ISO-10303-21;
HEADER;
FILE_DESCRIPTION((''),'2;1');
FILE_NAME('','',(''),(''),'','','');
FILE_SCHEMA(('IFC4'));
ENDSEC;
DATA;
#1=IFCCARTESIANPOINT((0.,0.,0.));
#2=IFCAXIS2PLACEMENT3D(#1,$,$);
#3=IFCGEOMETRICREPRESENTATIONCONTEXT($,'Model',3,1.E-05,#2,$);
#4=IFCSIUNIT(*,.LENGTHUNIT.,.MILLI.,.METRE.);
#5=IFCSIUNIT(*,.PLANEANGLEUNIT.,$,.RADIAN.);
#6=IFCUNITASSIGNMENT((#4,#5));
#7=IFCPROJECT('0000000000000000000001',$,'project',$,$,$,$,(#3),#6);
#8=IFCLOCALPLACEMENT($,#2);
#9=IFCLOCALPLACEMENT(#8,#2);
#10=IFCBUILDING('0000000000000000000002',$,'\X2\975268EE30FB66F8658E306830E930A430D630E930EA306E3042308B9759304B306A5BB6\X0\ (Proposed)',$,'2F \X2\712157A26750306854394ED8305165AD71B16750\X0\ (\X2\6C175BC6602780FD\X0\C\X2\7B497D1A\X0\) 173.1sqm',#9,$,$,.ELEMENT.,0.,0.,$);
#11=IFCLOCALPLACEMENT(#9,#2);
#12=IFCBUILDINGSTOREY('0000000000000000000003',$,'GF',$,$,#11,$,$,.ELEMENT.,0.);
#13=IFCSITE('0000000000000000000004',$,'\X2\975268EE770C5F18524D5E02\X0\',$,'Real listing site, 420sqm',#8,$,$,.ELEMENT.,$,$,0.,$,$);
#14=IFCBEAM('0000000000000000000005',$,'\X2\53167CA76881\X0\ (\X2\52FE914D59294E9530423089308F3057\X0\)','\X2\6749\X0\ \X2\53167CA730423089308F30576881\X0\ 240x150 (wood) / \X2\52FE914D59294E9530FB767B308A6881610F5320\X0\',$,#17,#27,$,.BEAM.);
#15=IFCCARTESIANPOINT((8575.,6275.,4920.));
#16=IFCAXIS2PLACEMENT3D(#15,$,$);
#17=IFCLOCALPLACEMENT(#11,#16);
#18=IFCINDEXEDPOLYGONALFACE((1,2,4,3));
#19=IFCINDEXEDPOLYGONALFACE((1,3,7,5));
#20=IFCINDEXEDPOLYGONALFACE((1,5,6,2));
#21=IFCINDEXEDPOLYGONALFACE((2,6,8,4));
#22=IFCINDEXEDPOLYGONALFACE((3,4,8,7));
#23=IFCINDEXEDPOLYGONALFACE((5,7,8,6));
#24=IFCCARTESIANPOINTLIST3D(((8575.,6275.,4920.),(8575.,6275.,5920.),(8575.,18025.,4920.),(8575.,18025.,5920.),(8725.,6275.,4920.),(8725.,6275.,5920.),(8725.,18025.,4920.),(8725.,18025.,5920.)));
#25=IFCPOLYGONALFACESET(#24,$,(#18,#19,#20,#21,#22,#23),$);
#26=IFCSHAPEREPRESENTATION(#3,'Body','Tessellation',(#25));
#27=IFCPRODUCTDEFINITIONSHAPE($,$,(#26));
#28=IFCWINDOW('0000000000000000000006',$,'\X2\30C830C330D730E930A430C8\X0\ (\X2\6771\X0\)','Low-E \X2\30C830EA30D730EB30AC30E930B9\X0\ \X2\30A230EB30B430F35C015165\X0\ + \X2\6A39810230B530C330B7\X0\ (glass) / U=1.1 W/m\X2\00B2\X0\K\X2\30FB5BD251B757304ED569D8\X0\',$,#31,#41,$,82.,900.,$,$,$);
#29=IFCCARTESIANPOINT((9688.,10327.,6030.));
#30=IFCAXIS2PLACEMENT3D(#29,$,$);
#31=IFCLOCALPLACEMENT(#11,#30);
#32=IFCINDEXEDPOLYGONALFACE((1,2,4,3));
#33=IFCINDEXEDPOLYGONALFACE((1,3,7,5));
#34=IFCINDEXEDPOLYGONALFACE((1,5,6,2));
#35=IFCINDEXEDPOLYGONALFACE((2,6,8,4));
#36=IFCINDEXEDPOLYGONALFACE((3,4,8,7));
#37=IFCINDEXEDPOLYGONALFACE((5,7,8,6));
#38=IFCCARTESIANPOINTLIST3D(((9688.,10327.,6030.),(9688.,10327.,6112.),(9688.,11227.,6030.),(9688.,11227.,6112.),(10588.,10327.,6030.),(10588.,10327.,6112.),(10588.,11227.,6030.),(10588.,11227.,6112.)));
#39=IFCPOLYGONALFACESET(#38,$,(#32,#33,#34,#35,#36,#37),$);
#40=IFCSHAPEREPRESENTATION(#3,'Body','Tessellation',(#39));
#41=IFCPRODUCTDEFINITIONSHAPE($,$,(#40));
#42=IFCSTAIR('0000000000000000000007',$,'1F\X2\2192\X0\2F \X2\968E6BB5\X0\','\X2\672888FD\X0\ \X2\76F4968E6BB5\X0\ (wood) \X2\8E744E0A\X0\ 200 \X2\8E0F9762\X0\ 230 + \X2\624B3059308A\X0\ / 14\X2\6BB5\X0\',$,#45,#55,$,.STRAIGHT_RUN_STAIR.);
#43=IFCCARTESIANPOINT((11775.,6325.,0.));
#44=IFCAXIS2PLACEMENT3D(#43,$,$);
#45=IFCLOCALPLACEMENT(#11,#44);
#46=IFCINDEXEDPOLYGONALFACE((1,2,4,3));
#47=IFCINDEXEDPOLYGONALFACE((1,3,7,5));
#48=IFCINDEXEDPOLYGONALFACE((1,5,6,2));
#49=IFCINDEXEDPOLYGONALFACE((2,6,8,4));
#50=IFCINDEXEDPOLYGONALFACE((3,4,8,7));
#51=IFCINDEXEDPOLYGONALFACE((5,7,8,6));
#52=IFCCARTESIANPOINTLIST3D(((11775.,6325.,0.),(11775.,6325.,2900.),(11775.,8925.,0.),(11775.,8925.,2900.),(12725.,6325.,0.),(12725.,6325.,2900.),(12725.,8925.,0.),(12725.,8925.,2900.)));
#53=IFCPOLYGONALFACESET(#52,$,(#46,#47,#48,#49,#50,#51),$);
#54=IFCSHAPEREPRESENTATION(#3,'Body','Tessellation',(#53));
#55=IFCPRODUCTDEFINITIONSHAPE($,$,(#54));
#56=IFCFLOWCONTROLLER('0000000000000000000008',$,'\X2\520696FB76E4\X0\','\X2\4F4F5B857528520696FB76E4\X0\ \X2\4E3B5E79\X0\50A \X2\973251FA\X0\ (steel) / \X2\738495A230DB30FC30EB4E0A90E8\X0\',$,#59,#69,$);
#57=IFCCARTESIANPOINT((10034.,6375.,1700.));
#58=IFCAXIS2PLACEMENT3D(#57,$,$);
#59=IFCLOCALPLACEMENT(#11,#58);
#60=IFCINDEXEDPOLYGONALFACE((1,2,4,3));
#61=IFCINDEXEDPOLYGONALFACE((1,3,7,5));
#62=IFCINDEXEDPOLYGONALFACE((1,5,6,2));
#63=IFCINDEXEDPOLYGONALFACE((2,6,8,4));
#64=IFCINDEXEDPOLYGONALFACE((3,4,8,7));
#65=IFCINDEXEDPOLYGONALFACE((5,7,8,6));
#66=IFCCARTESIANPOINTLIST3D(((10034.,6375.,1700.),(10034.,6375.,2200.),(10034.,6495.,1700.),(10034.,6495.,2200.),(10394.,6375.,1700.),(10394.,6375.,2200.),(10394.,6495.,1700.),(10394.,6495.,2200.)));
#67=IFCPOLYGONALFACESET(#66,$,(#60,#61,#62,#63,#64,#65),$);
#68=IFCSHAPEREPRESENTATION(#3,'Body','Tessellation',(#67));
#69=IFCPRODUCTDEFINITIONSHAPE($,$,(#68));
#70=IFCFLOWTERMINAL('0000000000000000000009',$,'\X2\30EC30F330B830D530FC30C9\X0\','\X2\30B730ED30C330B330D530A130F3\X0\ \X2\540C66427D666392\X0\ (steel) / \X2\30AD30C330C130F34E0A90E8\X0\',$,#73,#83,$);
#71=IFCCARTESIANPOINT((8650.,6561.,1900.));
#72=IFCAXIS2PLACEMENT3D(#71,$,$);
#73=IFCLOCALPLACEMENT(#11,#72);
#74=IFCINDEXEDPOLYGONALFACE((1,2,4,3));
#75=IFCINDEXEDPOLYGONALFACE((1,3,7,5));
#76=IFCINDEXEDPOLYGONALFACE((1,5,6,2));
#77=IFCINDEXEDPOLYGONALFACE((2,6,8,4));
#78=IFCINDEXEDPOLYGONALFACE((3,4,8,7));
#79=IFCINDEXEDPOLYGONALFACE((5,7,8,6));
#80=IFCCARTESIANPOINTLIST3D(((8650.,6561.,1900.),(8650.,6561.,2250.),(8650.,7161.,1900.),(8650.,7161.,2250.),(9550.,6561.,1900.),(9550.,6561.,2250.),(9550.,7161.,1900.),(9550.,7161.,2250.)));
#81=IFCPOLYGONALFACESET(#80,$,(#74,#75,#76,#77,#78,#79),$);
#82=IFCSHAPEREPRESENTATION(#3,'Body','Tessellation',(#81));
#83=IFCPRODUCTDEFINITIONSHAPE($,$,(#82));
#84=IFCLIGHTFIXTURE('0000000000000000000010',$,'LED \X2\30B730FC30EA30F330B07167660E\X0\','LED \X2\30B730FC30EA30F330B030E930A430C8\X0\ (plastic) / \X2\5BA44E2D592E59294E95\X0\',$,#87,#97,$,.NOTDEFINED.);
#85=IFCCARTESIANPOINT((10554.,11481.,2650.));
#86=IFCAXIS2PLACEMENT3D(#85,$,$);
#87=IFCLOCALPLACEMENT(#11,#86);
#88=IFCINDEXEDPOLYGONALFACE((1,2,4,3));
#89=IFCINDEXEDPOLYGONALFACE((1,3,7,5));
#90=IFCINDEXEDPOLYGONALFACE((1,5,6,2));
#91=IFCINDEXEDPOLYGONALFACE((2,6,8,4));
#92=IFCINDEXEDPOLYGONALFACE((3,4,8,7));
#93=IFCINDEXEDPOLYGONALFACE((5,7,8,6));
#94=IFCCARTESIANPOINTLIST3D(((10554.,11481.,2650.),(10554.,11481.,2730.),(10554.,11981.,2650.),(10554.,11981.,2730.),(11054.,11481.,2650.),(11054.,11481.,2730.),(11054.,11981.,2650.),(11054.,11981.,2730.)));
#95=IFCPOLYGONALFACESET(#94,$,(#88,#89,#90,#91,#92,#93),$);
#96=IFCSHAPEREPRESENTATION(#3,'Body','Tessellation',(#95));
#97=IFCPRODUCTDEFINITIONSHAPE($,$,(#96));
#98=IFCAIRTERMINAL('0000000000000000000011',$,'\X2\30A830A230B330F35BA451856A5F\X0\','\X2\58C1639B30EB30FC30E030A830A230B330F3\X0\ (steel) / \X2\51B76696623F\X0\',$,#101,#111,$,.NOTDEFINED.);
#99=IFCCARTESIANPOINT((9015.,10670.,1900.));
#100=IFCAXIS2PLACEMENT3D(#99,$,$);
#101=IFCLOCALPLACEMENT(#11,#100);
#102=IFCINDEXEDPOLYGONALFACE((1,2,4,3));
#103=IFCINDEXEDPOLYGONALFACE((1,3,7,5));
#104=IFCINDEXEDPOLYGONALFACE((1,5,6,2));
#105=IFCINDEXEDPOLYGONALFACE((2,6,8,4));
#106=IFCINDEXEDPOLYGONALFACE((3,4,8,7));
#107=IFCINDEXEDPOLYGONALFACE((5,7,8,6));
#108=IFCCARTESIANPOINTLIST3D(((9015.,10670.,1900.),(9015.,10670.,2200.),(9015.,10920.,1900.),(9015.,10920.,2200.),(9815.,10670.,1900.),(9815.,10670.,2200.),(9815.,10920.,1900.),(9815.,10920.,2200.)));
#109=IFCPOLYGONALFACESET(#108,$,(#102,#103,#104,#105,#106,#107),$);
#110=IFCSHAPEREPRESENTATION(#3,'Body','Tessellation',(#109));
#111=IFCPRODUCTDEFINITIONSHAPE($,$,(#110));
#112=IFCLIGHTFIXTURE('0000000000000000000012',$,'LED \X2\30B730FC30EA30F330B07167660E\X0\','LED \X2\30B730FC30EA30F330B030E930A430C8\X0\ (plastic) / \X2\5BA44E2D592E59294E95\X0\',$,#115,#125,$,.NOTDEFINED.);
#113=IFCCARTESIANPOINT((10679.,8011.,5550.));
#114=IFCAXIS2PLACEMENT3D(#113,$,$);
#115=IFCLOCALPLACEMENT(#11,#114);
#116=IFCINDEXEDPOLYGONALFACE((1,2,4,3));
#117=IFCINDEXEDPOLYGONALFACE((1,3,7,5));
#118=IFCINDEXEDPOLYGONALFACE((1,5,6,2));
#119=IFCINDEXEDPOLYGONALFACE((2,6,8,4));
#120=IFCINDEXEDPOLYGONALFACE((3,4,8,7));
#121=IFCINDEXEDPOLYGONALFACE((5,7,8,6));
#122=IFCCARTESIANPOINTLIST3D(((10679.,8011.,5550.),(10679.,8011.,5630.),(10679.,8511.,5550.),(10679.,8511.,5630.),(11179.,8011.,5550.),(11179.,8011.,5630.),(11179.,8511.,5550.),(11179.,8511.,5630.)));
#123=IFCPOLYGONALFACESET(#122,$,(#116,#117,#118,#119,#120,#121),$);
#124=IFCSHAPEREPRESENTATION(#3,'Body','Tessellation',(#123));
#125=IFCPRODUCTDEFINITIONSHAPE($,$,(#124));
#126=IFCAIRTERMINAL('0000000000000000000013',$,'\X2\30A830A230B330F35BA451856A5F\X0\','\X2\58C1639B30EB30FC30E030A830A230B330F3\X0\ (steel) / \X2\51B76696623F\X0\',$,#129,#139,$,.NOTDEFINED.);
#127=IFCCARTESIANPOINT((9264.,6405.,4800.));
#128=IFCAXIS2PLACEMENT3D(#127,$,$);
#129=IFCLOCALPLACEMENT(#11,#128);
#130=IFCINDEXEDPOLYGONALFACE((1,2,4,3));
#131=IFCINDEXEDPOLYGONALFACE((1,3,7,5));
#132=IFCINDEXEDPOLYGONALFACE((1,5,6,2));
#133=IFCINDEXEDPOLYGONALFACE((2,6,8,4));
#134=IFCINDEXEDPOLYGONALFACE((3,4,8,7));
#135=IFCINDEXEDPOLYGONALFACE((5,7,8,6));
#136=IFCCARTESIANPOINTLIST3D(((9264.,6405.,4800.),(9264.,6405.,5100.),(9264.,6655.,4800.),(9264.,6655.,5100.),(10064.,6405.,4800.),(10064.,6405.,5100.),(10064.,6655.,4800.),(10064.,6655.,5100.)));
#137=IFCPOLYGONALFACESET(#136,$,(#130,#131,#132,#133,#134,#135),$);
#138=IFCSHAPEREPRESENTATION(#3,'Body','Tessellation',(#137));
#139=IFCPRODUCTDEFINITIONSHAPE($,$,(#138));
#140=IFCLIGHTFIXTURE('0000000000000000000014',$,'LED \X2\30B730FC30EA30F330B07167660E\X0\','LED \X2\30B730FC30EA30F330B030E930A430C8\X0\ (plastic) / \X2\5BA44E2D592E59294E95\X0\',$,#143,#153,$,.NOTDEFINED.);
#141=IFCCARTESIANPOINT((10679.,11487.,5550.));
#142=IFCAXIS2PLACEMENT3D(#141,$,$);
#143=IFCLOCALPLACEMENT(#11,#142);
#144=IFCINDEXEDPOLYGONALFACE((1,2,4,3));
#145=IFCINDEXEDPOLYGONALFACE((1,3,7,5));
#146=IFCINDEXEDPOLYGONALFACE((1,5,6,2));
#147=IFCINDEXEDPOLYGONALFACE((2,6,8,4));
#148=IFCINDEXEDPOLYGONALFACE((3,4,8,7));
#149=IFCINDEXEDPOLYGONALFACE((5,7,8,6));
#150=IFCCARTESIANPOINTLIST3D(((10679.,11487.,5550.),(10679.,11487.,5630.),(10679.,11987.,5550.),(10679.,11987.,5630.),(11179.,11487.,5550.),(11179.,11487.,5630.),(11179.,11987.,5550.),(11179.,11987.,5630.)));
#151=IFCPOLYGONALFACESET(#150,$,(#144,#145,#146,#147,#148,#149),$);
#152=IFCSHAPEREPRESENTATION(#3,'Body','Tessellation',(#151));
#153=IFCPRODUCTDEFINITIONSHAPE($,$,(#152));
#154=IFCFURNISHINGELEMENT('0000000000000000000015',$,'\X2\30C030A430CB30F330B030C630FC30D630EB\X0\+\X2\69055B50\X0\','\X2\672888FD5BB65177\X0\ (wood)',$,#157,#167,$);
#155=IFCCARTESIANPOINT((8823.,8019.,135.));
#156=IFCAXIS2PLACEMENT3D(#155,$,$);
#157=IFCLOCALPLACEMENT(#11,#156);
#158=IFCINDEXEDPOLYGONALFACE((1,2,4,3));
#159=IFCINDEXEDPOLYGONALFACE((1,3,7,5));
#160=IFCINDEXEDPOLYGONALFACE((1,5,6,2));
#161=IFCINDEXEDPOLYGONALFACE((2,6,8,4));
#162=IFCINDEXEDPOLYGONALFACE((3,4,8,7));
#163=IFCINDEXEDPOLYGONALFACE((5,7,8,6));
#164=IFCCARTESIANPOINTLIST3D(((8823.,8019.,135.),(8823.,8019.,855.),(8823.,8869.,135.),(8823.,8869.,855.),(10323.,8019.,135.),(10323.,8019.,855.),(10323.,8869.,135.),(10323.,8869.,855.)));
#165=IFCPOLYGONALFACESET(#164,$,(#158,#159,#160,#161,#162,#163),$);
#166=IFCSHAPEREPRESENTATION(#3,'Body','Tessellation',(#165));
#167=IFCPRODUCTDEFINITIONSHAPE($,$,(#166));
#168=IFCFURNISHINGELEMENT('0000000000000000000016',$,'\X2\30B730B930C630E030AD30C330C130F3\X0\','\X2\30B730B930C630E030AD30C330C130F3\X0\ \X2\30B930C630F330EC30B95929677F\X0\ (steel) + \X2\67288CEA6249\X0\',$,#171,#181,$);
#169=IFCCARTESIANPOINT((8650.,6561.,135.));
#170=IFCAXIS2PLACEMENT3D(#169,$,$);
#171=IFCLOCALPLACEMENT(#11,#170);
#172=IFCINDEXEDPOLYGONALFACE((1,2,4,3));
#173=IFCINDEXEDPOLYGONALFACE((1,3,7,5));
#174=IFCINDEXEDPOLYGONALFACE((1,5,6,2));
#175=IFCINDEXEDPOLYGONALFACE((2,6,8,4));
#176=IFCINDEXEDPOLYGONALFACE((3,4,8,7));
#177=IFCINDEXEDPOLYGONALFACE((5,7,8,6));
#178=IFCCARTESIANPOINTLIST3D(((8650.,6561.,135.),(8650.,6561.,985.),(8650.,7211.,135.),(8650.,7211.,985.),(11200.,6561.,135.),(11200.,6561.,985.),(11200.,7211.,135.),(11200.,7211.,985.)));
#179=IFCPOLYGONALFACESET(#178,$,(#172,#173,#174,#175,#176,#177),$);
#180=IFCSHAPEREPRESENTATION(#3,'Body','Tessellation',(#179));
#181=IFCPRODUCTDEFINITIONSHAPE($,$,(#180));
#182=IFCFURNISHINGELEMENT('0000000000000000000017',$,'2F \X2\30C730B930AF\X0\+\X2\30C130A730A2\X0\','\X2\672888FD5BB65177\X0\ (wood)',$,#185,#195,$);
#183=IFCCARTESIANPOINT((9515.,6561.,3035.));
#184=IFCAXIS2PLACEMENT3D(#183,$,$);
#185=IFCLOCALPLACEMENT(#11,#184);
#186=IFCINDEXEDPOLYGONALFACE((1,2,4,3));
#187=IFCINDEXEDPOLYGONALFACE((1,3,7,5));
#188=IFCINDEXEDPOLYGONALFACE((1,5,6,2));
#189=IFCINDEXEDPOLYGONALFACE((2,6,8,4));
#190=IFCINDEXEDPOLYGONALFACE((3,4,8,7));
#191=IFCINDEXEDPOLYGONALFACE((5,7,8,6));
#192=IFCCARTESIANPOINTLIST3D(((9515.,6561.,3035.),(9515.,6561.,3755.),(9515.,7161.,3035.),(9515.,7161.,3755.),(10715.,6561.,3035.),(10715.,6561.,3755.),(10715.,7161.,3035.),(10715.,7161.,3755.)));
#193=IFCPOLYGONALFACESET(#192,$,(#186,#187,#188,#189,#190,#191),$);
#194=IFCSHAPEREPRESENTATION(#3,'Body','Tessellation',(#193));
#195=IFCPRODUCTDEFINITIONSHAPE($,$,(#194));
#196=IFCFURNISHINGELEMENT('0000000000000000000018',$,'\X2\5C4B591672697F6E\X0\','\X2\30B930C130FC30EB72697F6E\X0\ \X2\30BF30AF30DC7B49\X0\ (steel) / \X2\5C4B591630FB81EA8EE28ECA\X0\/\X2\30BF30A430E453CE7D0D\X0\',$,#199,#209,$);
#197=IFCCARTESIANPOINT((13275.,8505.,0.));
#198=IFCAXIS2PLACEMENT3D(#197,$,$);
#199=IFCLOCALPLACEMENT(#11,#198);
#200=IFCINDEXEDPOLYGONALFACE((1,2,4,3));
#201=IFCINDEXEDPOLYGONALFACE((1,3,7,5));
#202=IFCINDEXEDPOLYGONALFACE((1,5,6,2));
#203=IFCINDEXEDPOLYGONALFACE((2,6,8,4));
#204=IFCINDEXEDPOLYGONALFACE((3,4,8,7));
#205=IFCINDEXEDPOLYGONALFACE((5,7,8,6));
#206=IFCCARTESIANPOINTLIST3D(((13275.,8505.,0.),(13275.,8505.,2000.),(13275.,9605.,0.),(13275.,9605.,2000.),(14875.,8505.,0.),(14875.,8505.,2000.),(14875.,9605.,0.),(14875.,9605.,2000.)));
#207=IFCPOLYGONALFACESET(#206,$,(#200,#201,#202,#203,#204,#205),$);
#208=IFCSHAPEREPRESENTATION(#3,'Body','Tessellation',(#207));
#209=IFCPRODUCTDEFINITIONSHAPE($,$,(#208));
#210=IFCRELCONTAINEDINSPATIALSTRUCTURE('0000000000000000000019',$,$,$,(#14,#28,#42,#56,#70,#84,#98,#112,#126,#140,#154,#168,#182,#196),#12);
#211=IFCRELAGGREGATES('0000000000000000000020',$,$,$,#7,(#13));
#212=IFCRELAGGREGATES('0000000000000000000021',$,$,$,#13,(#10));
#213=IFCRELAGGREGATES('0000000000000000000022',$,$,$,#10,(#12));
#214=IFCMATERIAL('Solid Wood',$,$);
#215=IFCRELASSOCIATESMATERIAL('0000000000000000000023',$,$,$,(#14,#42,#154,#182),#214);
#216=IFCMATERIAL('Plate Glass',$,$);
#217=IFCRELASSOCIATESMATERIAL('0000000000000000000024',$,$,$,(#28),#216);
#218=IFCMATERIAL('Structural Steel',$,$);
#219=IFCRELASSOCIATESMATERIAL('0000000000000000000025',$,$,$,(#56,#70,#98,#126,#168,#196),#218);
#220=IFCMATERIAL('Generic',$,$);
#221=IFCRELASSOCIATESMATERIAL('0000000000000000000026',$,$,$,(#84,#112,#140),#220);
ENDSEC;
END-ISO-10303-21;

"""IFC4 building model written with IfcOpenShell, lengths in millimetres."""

from ifc_helpers import new_model, si_unit, frame, frame_2d, origin, place, context, project, spatial, rectangle, extrude, material, element, save


model = new_model("IFC4")

# Units and contexts
model_context = context("Model", 3, precision=1e-05, world=origin())
ifc_project = project(units=[si_unit("LENGTHUNIT", "METRE", prefix="MILLI"), si_unit("PLANEANGLEUNIT", "RADIAN")], contexts=[model_context])

# Site, building, storey
site_placement = place(None, origin())
site = spatial("IfcSite", under=ifc_project, at=site_placement, Name="青森県弘前市", ObjectType="Real listing site, 420sqm", CompositionType="ELEMENT", RefElevation=0.0)
building_placement = place(site_placement, origin())
building = spatial("IfcBuilding", under=site, at=building_placement, Name="青森・書斎とライブラリのある静かな家 (Proposed)", ObjectType="2F 無垢材と吹付け断熱材 (気密性能C等級) 173.1sqm", CompositionType="ELEMENT", ElevationOfRefHeight=0.0, ElevationOfTerrain=0.0)
storey_placement = place(building_placement, origin())
storey = spatial("IfcBuildingStorey", under=building, at=storey_placement, Name="GF", CompositionType="ELEMENT", Elevation=0.0)

# Shared definitions
ifc_material_1 = material(Name="Solid Wood")

# Beam
beam_placement = place(storey_placement, frame((8575.0, 6275.0, 4920.0)))
element("IfcBeam", 1, at=beam_placement, inside=storey, material=ifc_material_1, Name="化粧梁 (勾配天井あらわし)", Description="杉 化粧あらわし梁 240x150 (wood) / 勾配天井・登り梁意匠", PredefinedType="BEAM", context=model_context, shape_type="SweptSolid", body=[
    extrude(rectangle(XDim=150.0, YDim=11750.0, at=frame_2d((75.0, 5875.0))), frame((8575.0, 6275.0, 4920.0)), (0.0, 0.0, 1.0), 1000.0),
])

# Window
ifc_material_2 = material(Name="Plate Glass")
window_placement = place(storey_placement, frame((9688.0, 10327.0, 6030.0)))
element("IfcWindow", 2, at=window_placement, inside=storey, material=ifc_material_2, Name="トップライト (東)", Description="Low-E トリプルガラス アルゴン封入 + 樹脂サッシ (glass) / U=1.1 W/m²K・寒冷地仕様", OverallHeight=82.0, OverallWidth=900.0, context=model_context, shape_type="SweptSolid", body=[
    extrude(rectangle(XDim=900.0, YDim=900.0, at=frame_2d((450.0, 450.0))), frame((9688.0, 10327.0, 6030.0)), (0.0, 0.0, 1.0), 82.0),
])

# Stair
stair_placement = place(storey_placement, frame((11775.0, 6325.0, 0.0)))
element("IfcStair", 3, at=stair_placement, inside=storey, material=ifc_material_1, Name="1F→2F 階段", Description="木製 直階段 (wood) 蹴上 200 踏面 230 + 手すり / 14段", PredefinedType="STRAIGHT_RUN_STAIR", context=model_context, shape_type="SweptSolid", body=[
    extrude(rectangle(XDim=950.0, YDim=2600.0, at=frame_2d((475.0, 1300.0))), frame((11775.0, 6325.0, 0.0)), (0.0, 0.0, 1.0), 2900.0),
])

# Flow controller
ifc_material_3 = material(Name="Structural Steel")
flow_controller_placement = place(storey_placement, frame((10034.0, 6375.0, 1700.0)))
element("IfcFlowController", 4, at=flow_controller_placement, inside=storey, material=ifc_material_3, Name="分電盤", Description="住宅用分電盤 主幹50A 露出 (steel) / 玄関ホール上部", context=model_context, shape_type="SweptSolid", body=[
    extrude(rectangle(XDim=360.0, YDim=120.0, at=frame_2d((180.0, 60.0))), frame((10034.0, 6375.0, 1700.0)), (0.0, 0.0, 1.0), 500.0),
])

# Flow terminal
flow_terminal_placement = place(storey_placement, frame((8650.0, 6561.0, 1900.0)))
element("IfcFlowTerminal", 5, at=flow_terminal_placement, inside=storey, material=ifc_material_3, Name="レンジフード", Description="シロッコファン 同時給排 (steel) / キッチン上部", context=model_context, shape_type="SweptSolid", body=[
    extrude(rectangle(XDim=900.0, YDim=600.0, at=frame_2d((450.0, 300.0))), frame((8650.0, 6561.0, 1900.0)), (0.0, 0.0, 1.0), 350.0),
])

# Light fixture
ifc_material_4 = material(Name="Generic")
light_fixture_1_placement = place(storey_placement, frame((10554.0, 11481.0, 2650.0)))
element("IfcLightFixture", 6, at=light_fixture_1_placement, inside=storey, material=ifc_material_4, Name="LED シーリング照明", Description="LED シーリングライト (plastic) / 室中央天井", PredefinedType="NOTDEFINED", context=model_context, shape_type="SweptSolid", body=[
    extrude(rectangle(XDim=500.0, YDim=500.0, at=frame_2d((250.0, 250.0))), frame((10554.0, 11481.0, 2650.0)), (0.0, 0.0, 1.0), 80.0),
])

# Air terminal
air_terminal_1_placement = place(storey_placement, frame((9015.0, 10670.0, 1900.0)))
element("IfcAirTerminal", 7, at=air_terminal_1_placement, inside=storey, material=ifc_material_3, Name="エアコン室内機", Description="壁掛ルームエアコン (steel) / 冷暖房", PredefinedType="NOTDEFINED", context=model_context, shape_type="SweptSolid", body=[
    extrude(rectangle(XDim=800.0, YDim=250.0, at=frame_2d((400.0, 125.0))), frame((9015.0, 10670.0, 1900.0)), (0.0, 0.0, 1.0), 300.0),
])

# Light fixture
light_fixture_2_placement = place(storey_placement, frame((10679.0, 8011.0, 5550.0)))
element("IfcLightFixture", 8, at=light_fixture_2_placement, inside=storey, material=ifc_material_4, Name="LED シーリング照明", Description="LED シーリングライト (plastic) / 室中央天井", PredefinedType="NOTDEFINED", context=model_context, shape_type="SweptSolid", body=[
    extrude(rectangle(XDim=500.0, YDim=500.0, at=frame_2d((250.0, 250.0))), frame((10679.0, 8011.0, 5550.0)), (0.0, 0.0, 1.0), 80.0),
])

# Air terminal
air_terminal_2_placement = place(storey_placement, frame((9264.0, 6405.0, 4800.0)))
element("IfcAirTerminal", 9, at=air_terminal_2_placement, inside=storey, material=ifc_material_3, Name="エアコン室内機", Description="壁掛ルームエアコン (steel) / 冷暖房", PredefinedType="NOTDEFINED", context=model_context, shape_type="SweptSolid", body=[
    extrude(rectangle(XDim=800.0, YDim=250.0, at=frame_2d((400.0, 125.0))), frame((9264.0, 6405.0, 4800.0)), (0.0, 0.0, 1.0), 300.0),
])

# Light fixture
light_fixture_3_placement = place(storey_placement, frame((10679.0, 11487.0, 5550.0)))
element("IfcLightFixture", 10, at=light_fixture_3_placement, inside=storey, material=ifc_material_4, Name="LED シーリング照明", Description="LED シーリングライト (plastic) / 室中央天井", PredefinedType="NOTDEFINED", context=model_context, shape_type="SweptSolid", body=[
    extrude(rectangle(XDim=500.0, YDim=500.0, at=frame_2d((250.0, 250.0))), frame((10679.0, 11487.0, 5550.0)), (0.0, 0.0, 1.0), 80.0),
])

# Furnishing elements
furnishing_1_placement = place(storey_placement, frame((8823.0, 8019.0, 135.0)))
element("IfcFurnishingElement", 11, at=furnishing_1_placement, inside=storey, material=ifc_material_1, Name="ダイニングテーブル+椅子", Description="木製家具 (wood)", context=model_context, shape_type="SweptSolid", body=[
    extrude(rectangle(XDim=1500.0, YDim=850.0, at=frame_2d((750.0, 425.0))), frame((8823.0, 8019.0, 135.0)), (0.0, 0.0, 1.0), 720.0),
])
furnishing_2_placement = place(storey_placement, frame((8650.0, 6561.0, 135.0)))
element("IfcFurnishingElement", 12, at=furnishing_2_placement, inside=storey, material=ifc_material_3, Name="システムキッチン", Description="システムキッチン ステンレス天板 (steel) + 木質扉", context=model_context, shape_type="SweptSolid", body=[
    extrude(rectangle(XDim=2550.0, YDim=650.0, at=frame_2d((1275.0, 325.0))), frame((8650.0, 6561.0, 135.0)), (0.0, 0.0, 1.0), 850.0),
])
furnishing_3_placement = place(storey_placement, frame((9515.0, 6561.0, 3035.0)))
element("IfcFurnishingElement", 13, at=furnishing_3_placement, inside=storey, material=ifc_material_1, Name="2F デスク+チェア", Description="木製家具 (wood)", context=model_context, shape_type="SweptSolid", body=[
    extrude(rectangle(XDim=1200.0, YDim=600.0, at=frame_2d((600.0, 300.0))), frame((9515.0, 6561.0, 3035.0)), (0.0, 0.0, 1.0), 720.0),
])
furnishing_4_placement = place(storey_placement, frame((13275.0, 8505.0, 0.0)))
element("IfcFurnishingElement", 14, at=furnishing_4_placement, inside=storey, material=ifc_material_3, Name="屋外物置", Description="スチール物置 タクボ等 (steel) / 屋外・自転車/タイヤ収納", context=model_context, shape_type="SweptSolid", body=[
    extrude(rectangle(XDim=1600.0, YDim=1100.0, at=frame_2d((800.0, 550.0))), frame((13275.0, 8505.0, 0.0)), (0.0, 0.0, 1.0), 2000.0),
])

save(model, "model.ifc")
